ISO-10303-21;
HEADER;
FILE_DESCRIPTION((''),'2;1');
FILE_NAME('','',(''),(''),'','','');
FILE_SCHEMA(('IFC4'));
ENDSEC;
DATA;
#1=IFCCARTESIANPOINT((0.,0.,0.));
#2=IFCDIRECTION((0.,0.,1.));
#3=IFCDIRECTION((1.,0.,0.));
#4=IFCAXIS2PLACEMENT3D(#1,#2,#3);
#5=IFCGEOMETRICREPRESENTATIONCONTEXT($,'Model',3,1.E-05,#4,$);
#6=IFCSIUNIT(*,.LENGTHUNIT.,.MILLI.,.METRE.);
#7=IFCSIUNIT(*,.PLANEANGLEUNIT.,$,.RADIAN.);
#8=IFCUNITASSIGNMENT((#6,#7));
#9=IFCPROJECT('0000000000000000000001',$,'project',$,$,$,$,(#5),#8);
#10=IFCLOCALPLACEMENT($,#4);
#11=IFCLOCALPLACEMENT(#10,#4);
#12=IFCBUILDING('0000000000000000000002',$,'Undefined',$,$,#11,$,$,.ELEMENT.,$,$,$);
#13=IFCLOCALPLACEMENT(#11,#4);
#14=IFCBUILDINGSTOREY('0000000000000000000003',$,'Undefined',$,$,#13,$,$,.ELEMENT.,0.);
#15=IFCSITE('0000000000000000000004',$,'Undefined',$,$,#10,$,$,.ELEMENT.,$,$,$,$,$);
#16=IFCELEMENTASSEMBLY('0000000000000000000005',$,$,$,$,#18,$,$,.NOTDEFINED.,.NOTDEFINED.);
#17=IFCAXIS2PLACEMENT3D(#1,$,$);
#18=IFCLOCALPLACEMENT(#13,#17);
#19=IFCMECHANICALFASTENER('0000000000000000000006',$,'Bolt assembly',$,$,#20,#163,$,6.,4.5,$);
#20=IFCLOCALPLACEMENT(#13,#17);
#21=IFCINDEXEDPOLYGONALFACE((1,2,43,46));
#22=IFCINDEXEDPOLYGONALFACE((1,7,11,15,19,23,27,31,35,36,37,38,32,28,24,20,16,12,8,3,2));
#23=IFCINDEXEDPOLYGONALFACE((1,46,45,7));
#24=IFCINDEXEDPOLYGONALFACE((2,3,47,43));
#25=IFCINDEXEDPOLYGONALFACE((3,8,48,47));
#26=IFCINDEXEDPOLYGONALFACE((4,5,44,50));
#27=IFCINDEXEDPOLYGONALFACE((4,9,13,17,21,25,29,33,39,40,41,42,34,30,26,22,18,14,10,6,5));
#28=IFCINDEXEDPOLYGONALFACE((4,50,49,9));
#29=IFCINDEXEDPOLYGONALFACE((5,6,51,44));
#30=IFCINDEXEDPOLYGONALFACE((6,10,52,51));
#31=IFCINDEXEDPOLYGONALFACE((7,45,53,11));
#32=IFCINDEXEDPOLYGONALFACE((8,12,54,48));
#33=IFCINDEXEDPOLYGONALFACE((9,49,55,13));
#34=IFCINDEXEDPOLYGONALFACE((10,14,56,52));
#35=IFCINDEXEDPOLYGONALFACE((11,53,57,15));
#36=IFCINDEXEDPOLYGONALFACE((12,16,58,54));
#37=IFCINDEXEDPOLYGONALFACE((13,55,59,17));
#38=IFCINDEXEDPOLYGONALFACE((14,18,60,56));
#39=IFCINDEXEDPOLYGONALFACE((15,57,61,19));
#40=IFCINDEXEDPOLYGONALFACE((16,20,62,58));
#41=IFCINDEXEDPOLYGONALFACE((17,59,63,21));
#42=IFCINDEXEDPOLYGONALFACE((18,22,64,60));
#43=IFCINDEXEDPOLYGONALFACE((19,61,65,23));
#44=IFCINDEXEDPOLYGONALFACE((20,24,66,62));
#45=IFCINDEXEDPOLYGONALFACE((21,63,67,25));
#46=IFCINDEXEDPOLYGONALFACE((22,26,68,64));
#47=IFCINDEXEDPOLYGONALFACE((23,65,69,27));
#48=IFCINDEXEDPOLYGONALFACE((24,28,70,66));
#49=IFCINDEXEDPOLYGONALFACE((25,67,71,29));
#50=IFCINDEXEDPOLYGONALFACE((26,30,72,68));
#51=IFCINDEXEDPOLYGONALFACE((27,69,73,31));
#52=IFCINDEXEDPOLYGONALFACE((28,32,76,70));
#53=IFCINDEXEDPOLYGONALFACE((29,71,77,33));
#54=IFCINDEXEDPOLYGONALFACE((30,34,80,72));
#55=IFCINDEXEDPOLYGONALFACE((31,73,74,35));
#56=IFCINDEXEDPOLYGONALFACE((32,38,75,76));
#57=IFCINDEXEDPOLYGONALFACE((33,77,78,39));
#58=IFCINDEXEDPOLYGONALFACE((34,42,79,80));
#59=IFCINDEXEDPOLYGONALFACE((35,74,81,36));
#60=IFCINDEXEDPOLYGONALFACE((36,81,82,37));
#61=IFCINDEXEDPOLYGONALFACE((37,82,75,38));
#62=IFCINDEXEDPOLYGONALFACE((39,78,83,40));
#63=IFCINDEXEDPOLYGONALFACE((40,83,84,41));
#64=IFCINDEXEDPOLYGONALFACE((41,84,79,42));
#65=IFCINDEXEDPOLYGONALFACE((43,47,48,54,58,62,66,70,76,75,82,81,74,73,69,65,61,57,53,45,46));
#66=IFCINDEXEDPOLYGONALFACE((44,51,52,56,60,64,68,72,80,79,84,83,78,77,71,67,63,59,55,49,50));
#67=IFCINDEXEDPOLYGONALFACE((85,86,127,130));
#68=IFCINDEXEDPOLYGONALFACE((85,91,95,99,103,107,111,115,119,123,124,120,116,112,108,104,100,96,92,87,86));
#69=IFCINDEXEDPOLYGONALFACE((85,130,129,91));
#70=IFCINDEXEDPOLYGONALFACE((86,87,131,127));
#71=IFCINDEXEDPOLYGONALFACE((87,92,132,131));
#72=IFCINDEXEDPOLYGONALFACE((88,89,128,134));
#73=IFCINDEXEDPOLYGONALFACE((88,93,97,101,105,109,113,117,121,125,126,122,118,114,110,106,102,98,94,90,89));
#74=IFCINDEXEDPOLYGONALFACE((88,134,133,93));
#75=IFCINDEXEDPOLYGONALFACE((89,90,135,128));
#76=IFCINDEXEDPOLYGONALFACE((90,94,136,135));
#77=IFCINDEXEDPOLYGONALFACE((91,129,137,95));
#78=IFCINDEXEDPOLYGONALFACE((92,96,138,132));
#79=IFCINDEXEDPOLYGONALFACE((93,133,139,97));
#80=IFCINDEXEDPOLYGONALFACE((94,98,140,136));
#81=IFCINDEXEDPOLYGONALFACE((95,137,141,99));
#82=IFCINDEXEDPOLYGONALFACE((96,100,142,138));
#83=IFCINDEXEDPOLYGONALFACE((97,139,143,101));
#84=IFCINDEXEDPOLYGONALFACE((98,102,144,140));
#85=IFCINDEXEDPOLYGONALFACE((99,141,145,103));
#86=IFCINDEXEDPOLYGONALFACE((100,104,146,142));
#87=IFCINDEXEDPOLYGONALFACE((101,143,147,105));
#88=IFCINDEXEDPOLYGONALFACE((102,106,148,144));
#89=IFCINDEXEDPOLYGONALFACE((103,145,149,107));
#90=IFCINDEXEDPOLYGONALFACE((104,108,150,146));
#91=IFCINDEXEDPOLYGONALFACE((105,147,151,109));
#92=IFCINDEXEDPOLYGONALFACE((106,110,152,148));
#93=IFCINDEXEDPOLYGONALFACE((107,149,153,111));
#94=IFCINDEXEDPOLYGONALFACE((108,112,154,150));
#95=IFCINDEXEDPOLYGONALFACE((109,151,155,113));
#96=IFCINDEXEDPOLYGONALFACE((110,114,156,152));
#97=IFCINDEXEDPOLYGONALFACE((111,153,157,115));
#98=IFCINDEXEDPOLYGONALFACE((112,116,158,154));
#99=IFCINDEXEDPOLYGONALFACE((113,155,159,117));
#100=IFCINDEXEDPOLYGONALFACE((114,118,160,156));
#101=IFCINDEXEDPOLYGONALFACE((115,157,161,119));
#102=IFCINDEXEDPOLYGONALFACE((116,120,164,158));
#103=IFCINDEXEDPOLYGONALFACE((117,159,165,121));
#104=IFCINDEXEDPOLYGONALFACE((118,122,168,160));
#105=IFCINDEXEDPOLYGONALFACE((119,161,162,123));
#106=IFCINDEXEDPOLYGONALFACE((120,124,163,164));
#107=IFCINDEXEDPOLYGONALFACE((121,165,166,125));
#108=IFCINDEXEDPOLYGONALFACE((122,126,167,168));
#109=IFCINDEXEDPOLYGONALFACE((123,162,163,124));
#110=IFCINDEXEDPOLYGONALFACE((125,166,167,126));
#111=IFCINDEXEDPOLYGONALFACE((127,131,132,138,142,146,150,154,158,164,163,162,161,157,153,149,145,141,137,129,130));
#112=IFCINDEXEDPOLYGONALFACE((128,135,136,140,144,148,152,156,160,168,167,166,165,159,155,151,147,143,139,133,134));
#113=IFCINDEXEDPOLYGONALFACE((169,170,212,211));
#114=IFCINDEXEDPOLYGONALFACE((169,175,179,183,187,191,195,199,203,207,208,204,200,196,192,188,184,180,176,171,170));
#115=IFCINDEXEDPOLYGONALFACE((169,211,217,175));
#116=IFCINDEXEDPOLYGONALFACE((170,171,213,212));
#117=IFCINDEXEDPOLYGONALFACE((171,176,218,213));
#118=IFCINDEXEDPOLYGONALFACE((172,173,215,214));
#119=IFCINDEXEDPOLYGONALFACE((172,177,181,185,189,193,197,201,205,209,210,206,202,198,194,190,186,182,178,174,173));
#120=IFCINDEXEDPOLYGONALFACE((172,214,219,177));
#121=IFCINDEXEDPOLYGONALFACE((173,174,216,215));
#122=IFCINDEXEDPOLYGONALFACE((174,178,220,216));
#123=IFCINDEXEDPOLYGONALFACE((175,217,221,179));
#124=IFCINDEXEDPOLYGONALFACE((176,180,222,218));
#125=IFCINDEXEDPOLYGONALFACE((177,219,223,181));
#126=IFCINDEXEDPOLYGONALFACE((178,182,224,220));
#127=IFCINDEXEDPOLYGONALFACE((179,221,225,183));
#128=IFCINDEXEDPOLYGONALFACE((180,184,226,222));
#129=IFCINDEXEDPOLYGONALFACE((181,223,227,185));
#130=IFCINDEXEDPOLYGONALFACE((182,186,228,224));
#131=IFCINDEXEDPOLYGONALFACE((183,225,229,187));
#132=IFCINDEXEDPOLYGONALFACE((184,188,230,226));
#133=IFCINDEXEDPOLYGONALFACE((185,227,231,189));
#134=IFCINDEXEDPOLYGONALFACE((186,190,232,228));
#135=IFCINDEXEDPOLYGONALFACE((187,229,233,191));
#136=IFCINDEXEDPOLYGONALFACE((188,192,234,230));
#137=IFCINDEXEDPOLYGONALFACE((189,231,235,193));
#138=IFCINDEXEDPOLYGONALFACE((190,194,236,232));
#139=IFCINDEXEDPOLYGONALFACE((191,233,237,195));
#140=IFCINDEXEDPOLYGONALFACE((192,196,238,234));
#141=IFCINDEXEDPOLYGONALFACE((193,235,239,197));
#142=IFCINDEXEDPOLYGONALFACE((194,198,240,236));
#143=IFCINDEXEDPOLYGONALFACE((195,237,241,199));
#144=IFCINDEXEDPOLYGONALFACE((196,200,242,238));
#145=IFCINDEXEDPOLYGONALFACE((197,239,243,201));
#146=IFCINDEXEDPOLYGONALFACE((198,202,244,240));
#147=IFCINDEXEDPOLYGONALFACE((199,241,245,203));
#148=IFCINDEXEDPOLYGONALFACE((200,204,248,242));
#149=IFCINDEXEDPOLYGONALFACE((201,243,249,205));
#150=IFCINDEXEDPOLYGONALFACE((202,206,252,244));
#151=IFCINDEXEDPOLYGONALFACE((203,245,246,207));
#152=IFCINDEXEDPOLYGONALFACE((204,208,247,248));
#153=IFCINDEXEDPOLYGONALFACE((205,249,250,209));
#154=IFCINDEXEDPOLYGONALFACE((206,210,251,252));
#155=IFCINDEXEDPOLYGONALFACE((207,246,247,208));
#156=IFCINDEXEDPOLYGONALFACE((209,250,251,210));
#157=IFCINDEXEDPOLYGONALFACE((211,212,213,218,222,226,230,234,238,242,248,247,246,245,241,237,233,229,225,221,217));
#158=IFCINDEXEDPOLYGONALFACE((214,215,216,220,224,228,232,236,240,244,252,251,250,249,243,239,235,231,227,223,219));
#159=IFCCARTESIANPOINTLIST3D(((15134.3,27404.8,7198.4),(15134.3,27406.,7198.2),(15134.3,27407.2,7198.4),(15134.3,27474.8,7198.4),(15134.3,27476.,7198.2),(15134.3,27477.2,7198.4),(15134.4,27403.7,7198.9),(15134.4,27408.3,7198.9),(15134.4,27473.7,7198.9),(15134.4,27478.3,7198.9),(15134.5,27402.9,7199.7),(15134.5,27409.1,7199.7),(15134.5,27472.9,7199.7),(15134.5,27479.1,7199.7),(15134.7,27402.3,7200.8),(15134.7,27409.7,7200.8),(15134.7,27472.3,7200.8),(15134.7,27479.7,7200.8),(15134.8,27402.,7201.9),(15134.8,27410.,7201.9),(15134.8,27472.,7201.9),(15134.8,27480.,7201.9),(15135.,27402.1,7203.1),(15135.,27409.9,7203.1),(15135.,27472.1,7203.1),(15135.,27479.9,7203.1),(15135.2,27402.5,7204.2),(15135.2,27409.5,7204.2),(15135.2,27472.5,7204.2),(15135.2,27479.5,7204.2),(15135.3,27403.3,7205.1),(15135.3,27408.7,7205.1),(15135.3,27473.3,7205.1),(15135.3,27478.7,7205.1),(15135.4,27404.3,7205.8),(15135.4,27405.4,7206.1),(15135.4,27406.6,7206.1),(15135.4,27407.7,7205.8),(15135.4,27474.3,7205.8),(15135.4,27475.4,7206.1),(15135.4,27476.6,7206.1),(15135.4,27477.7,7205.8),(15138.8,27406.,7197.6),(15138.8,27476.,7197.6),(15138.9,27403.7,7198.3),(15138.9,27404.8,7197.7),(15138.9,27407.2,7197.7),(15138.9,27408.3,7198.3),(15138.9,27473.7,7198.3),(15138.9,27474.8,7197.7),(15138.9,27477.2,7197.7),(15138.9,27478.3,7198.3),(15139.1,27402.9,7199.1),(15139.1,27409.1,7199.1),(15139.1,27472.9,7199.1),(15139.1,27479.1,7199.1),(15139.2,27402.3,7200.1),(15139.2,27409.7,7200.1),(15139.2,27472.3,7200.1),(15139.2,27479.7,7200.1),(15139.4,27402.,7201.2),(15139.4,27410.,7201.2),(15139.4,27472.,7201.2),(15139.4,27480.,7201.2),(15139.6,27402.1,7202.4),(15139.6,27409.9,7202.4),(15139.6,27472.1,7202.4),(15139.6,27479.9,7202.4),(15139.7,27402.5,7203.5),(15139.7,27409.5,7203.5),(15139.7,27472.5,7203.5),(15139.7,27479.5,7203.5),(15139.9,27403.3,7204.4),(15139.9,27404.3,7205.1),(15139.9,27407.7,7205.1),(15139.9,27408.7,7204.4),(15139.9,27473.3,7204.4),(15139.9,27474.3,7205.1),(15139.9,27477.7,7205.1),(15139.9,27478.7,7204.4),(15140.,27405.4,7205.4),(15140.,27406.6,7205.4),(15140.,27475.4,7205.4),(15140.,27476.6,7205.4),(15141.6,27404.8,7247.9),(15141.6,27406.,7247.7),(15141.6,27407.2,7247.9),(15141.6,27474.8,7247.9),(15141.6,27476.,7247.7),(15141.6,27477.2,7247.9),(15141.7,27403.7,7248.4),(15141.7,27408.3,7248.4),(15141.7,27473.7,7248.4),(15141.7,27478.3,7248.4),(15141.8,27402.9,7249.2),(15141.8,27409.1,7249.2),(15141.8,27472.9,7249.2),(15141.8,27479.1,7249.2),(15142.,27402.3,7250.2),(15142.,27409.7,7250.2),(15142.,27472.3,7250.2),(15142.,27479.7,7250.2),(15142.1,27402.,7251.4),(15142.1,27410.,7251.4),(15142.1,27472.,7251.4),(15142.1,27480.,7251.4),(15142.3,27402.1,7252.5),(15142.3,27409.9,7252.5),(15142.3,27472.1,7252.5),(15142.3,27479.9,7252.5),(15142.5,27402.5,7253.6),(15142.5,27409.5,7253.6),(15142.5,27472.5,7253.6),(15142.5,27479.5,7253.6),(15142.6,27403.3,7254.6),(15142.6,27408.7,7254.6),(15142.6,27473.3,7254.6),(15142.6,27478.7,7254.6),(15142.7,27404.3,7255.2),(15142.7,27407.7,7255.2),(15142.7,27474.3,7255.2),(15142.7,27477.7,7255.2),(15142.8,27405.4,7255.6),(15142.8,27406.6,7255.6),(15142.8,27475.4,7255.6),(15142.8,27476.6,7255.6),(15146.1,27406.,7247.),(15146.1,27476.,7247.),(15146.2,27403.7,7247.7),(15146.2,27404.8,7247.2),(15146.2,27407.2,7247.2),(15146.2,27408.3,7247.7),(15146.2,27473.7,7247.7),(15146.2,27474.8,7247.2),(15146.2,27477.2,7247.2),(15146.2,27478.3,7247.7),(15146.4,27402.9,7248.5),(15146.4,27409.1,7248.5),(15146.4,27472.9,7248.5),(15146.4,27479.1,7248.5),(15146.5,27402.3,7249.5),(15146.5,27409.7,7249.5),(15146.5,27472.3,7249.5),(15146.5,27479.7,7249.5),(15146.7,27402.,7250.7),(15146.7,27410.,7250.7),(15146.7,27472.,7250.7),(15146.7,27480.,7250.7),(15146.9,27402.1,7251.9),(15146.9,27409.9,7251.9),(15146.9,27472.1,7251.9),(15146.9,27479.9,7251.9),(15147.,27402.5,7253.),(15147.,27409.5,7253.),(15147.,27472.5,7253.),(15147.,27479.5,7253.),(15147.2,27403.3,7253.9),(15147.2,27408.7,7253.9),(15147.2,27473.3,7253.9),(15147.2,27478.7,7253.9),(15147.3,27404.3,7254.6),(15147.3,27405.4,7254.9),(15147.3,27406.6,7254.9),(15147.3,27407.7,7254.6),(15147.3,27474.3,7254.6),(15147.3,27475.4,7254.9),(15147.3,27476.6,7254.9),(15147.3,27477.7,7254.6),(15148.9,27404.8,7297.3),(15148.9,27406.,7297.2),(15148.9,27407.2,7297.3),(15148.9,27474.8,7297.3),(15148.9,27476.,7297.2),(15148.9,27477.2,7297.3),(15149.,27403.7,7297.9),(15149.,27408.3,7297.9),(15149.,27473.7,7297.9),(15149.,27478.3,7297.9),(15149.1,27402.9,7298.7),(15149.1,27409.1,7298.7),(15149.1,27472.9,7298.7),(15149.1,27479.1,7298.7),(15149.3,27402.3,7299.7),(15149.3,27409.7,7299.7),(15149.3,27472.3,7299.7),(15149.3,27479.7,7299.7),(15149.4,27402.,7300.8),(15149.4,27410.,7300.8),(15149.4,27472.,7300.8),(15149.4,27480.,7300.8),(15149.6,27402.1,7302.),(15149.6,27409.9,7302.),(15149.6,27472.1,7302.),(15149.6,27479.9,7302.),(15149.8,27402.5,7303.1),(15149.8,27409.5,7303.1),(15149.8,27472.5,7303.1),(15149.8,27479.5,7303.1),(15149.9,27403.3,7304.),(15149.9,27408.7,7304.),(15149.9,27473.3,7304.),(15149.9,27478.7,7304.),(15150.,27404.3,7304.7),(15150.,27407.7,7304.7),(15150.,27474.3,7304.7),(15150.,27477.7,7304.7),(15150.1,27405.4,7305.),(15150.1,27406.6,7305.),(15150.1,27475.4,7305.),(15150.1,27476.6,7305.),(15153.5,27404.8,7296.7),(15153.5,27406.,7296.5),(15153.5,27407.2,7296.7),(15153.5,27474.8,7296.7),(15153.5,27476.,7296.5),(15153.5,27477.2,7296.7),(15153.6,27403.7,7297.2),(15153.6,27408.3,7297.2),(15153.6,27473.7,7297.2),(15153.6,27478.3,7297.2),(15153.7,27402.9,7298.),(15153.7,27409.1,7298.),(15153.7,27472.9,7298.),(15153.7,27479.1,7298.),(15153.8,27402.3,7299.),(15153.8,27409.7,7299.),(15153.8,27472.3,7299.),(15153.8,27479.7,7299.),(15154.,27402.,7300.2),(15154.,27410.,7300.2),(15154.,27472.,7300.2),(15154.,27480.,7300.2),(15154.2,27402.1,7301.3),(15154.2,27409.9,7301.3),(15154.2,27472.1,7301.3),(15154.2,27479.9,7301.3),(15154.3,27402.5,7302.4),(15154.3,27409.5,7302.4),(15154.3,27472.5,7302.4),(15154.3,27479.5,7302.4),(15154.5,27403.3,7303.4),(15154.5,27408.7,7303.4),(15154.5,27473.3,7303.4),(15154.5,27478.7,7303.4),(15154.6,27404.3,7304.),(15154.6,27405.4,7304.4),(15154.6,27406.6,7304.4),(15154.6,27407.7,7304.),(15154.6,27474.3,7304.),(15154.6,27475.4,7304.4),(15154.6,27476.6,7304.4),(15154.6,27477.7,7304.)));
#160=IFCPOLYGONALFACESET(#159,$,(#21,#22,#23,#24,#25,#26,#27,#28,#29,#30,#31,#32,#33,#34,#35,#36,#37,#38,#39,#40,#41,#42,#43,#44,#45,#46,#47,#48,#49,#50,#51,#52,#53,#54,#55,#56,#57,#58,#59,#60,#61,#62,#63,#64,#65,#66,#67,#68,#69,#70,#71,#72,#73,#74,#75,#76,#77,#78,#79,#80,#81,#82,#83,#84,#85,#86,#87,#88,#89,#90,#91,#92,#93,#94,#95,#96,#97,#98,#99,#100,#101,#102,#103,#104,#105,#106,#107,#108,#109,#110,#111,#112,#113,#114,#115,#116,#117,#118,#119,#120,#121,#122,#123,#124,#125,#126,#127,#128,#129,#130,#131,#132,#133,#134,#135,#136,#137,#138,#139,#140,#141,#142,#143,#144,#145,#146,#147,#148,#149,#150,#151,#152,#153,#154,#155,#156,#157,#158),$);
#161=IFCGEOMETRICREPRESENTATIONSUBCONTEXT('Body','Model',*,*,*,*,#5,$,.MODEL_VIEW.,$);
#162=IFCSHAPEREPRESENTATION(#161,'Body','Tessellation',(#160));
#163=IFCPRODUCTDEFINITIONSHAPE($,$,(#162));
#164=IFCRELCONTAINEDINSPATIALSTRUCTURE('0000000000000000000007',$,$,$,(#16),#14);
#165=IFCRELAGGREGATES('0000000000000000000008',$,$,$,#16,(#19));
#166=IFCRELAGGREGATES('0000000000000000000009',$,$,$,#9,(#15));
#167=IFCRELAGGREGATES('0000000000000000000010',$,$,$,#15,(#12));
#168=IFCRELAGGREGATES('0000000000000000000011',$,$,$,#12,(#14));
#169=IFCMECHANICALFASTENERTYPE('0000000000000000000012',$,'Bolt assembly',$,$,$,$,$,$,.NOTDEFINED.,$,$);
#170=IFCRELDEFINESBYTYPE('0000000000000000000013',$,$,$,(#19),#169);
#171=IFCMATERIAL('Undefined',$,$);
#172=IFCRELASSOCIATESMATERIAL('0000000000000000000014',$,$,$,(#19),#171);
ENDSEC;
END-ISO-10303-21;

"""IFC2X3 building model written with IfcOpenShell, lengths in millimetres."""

from ifc_helpers import new_model, si_unit, frame, origin_with_axes, origin_2d_with_axis, place, context, subcontext, project, spatial, circle, extrude, source, transform, mapped, material, type_object, element, aggregate, save


model = new_model("IFC2X3")

# Units and contexts
model_context = context("Model", 3, precision=1e-05, world=origin_with_axes())
body_context = subcontext(model_context, "Body", "Model", "MODEL_VIEW")
ifc_project = project(units=[si_unit("LENGTHUNIT", "METRE", prefix="MILLI"), si_unit("PLANEANGLEUNIT", "RADIAN")], contexts=[model_context])

# Site, building, storey
site_placement = place(None, origin_with_axes())
site = spatial("IfcSite", under=ifc_project, at=site_placement, Name="Undefined", CompositionType="ELEMENT")
building_placement = place(site_placement, origin_with_axes())
building = spatial("IfcBuilding", under=site, at=building_placement, Name="Undefined", CompositionType="ELEMENT")
storey_placement = place(building_placement, origin_with_axes())
storey = spatial("IfcBuildingStorey", under=building, at=storey_placement, Name="Undefined", CompositionType="ELEMENT", Elevation=0.0)

# Element assembly
assembly_1_placement = place(storey_placement, origin_with_axes())
assembly_1 = element("IfcElementAssembly", 1, at=assembly_1_placement, inside=storey, AssemblyPlace="NOTDEFINED", PredefinedType="NOTDEFINED")

# Mechanical fastener
ifc_material_1 = material(Name="Undefined")
mechanical_fastener_type = type_object("IfcMechanicalFastenerType", Name="Bolt assembly")
shared_shape_1 = source(origin_with_axes(), body_context, "Body", "SweptSolid", [
    extrude(circle(Radius=4.0, at=origin_2d_with_axis()), frame((0.0, 0.0, 0.0), z_axis=(0.0, 1.0, 0.0), x_axis=(1.0, 0.0, 0.0)), (0.0, 0.0, 1.0), 4.6),
])
mechanical_fastener_1_placement = place(assembly_1_placement, frame((15154.0, 27441.0, 7300.5), z_axis=(0.0, 1.0, 0.0), x_axis=(-0.146202, 0.0, -0.989255)))
mechanical_fastener_1 = element("IfcMechanicalFastener", 2, at=mechanical_fastener_1_placement, type_object=mechanical_fastener_type, material=ifc_material_1, Name="Bolt assembly", NominalDiameter=6.0, NominalLength=4.5, context=body_context, shape_type="MappedRepresentation", body=[
    mapped(shared_shape_1, transform((0.0, 0.0, 35.0))),
    mapped(shared_shape_1, transform((50.0, 0.0, 35.0))),
    mapped(shared_shape_1, transform((100.0, 0.0, 35.0))),
    mapped(shared_shape_1, transform((0.0, 0.0, -35.0))),
    mapped(shared_shape_1, transform((50.0, 0.0, -35.0))),
    mapped(shared_shape_1, transform((100.0, 0.0, -35.0))),
])

aggregate(assembly_1, [mechanical_fastener_1])

save(model, "model.ifc")
